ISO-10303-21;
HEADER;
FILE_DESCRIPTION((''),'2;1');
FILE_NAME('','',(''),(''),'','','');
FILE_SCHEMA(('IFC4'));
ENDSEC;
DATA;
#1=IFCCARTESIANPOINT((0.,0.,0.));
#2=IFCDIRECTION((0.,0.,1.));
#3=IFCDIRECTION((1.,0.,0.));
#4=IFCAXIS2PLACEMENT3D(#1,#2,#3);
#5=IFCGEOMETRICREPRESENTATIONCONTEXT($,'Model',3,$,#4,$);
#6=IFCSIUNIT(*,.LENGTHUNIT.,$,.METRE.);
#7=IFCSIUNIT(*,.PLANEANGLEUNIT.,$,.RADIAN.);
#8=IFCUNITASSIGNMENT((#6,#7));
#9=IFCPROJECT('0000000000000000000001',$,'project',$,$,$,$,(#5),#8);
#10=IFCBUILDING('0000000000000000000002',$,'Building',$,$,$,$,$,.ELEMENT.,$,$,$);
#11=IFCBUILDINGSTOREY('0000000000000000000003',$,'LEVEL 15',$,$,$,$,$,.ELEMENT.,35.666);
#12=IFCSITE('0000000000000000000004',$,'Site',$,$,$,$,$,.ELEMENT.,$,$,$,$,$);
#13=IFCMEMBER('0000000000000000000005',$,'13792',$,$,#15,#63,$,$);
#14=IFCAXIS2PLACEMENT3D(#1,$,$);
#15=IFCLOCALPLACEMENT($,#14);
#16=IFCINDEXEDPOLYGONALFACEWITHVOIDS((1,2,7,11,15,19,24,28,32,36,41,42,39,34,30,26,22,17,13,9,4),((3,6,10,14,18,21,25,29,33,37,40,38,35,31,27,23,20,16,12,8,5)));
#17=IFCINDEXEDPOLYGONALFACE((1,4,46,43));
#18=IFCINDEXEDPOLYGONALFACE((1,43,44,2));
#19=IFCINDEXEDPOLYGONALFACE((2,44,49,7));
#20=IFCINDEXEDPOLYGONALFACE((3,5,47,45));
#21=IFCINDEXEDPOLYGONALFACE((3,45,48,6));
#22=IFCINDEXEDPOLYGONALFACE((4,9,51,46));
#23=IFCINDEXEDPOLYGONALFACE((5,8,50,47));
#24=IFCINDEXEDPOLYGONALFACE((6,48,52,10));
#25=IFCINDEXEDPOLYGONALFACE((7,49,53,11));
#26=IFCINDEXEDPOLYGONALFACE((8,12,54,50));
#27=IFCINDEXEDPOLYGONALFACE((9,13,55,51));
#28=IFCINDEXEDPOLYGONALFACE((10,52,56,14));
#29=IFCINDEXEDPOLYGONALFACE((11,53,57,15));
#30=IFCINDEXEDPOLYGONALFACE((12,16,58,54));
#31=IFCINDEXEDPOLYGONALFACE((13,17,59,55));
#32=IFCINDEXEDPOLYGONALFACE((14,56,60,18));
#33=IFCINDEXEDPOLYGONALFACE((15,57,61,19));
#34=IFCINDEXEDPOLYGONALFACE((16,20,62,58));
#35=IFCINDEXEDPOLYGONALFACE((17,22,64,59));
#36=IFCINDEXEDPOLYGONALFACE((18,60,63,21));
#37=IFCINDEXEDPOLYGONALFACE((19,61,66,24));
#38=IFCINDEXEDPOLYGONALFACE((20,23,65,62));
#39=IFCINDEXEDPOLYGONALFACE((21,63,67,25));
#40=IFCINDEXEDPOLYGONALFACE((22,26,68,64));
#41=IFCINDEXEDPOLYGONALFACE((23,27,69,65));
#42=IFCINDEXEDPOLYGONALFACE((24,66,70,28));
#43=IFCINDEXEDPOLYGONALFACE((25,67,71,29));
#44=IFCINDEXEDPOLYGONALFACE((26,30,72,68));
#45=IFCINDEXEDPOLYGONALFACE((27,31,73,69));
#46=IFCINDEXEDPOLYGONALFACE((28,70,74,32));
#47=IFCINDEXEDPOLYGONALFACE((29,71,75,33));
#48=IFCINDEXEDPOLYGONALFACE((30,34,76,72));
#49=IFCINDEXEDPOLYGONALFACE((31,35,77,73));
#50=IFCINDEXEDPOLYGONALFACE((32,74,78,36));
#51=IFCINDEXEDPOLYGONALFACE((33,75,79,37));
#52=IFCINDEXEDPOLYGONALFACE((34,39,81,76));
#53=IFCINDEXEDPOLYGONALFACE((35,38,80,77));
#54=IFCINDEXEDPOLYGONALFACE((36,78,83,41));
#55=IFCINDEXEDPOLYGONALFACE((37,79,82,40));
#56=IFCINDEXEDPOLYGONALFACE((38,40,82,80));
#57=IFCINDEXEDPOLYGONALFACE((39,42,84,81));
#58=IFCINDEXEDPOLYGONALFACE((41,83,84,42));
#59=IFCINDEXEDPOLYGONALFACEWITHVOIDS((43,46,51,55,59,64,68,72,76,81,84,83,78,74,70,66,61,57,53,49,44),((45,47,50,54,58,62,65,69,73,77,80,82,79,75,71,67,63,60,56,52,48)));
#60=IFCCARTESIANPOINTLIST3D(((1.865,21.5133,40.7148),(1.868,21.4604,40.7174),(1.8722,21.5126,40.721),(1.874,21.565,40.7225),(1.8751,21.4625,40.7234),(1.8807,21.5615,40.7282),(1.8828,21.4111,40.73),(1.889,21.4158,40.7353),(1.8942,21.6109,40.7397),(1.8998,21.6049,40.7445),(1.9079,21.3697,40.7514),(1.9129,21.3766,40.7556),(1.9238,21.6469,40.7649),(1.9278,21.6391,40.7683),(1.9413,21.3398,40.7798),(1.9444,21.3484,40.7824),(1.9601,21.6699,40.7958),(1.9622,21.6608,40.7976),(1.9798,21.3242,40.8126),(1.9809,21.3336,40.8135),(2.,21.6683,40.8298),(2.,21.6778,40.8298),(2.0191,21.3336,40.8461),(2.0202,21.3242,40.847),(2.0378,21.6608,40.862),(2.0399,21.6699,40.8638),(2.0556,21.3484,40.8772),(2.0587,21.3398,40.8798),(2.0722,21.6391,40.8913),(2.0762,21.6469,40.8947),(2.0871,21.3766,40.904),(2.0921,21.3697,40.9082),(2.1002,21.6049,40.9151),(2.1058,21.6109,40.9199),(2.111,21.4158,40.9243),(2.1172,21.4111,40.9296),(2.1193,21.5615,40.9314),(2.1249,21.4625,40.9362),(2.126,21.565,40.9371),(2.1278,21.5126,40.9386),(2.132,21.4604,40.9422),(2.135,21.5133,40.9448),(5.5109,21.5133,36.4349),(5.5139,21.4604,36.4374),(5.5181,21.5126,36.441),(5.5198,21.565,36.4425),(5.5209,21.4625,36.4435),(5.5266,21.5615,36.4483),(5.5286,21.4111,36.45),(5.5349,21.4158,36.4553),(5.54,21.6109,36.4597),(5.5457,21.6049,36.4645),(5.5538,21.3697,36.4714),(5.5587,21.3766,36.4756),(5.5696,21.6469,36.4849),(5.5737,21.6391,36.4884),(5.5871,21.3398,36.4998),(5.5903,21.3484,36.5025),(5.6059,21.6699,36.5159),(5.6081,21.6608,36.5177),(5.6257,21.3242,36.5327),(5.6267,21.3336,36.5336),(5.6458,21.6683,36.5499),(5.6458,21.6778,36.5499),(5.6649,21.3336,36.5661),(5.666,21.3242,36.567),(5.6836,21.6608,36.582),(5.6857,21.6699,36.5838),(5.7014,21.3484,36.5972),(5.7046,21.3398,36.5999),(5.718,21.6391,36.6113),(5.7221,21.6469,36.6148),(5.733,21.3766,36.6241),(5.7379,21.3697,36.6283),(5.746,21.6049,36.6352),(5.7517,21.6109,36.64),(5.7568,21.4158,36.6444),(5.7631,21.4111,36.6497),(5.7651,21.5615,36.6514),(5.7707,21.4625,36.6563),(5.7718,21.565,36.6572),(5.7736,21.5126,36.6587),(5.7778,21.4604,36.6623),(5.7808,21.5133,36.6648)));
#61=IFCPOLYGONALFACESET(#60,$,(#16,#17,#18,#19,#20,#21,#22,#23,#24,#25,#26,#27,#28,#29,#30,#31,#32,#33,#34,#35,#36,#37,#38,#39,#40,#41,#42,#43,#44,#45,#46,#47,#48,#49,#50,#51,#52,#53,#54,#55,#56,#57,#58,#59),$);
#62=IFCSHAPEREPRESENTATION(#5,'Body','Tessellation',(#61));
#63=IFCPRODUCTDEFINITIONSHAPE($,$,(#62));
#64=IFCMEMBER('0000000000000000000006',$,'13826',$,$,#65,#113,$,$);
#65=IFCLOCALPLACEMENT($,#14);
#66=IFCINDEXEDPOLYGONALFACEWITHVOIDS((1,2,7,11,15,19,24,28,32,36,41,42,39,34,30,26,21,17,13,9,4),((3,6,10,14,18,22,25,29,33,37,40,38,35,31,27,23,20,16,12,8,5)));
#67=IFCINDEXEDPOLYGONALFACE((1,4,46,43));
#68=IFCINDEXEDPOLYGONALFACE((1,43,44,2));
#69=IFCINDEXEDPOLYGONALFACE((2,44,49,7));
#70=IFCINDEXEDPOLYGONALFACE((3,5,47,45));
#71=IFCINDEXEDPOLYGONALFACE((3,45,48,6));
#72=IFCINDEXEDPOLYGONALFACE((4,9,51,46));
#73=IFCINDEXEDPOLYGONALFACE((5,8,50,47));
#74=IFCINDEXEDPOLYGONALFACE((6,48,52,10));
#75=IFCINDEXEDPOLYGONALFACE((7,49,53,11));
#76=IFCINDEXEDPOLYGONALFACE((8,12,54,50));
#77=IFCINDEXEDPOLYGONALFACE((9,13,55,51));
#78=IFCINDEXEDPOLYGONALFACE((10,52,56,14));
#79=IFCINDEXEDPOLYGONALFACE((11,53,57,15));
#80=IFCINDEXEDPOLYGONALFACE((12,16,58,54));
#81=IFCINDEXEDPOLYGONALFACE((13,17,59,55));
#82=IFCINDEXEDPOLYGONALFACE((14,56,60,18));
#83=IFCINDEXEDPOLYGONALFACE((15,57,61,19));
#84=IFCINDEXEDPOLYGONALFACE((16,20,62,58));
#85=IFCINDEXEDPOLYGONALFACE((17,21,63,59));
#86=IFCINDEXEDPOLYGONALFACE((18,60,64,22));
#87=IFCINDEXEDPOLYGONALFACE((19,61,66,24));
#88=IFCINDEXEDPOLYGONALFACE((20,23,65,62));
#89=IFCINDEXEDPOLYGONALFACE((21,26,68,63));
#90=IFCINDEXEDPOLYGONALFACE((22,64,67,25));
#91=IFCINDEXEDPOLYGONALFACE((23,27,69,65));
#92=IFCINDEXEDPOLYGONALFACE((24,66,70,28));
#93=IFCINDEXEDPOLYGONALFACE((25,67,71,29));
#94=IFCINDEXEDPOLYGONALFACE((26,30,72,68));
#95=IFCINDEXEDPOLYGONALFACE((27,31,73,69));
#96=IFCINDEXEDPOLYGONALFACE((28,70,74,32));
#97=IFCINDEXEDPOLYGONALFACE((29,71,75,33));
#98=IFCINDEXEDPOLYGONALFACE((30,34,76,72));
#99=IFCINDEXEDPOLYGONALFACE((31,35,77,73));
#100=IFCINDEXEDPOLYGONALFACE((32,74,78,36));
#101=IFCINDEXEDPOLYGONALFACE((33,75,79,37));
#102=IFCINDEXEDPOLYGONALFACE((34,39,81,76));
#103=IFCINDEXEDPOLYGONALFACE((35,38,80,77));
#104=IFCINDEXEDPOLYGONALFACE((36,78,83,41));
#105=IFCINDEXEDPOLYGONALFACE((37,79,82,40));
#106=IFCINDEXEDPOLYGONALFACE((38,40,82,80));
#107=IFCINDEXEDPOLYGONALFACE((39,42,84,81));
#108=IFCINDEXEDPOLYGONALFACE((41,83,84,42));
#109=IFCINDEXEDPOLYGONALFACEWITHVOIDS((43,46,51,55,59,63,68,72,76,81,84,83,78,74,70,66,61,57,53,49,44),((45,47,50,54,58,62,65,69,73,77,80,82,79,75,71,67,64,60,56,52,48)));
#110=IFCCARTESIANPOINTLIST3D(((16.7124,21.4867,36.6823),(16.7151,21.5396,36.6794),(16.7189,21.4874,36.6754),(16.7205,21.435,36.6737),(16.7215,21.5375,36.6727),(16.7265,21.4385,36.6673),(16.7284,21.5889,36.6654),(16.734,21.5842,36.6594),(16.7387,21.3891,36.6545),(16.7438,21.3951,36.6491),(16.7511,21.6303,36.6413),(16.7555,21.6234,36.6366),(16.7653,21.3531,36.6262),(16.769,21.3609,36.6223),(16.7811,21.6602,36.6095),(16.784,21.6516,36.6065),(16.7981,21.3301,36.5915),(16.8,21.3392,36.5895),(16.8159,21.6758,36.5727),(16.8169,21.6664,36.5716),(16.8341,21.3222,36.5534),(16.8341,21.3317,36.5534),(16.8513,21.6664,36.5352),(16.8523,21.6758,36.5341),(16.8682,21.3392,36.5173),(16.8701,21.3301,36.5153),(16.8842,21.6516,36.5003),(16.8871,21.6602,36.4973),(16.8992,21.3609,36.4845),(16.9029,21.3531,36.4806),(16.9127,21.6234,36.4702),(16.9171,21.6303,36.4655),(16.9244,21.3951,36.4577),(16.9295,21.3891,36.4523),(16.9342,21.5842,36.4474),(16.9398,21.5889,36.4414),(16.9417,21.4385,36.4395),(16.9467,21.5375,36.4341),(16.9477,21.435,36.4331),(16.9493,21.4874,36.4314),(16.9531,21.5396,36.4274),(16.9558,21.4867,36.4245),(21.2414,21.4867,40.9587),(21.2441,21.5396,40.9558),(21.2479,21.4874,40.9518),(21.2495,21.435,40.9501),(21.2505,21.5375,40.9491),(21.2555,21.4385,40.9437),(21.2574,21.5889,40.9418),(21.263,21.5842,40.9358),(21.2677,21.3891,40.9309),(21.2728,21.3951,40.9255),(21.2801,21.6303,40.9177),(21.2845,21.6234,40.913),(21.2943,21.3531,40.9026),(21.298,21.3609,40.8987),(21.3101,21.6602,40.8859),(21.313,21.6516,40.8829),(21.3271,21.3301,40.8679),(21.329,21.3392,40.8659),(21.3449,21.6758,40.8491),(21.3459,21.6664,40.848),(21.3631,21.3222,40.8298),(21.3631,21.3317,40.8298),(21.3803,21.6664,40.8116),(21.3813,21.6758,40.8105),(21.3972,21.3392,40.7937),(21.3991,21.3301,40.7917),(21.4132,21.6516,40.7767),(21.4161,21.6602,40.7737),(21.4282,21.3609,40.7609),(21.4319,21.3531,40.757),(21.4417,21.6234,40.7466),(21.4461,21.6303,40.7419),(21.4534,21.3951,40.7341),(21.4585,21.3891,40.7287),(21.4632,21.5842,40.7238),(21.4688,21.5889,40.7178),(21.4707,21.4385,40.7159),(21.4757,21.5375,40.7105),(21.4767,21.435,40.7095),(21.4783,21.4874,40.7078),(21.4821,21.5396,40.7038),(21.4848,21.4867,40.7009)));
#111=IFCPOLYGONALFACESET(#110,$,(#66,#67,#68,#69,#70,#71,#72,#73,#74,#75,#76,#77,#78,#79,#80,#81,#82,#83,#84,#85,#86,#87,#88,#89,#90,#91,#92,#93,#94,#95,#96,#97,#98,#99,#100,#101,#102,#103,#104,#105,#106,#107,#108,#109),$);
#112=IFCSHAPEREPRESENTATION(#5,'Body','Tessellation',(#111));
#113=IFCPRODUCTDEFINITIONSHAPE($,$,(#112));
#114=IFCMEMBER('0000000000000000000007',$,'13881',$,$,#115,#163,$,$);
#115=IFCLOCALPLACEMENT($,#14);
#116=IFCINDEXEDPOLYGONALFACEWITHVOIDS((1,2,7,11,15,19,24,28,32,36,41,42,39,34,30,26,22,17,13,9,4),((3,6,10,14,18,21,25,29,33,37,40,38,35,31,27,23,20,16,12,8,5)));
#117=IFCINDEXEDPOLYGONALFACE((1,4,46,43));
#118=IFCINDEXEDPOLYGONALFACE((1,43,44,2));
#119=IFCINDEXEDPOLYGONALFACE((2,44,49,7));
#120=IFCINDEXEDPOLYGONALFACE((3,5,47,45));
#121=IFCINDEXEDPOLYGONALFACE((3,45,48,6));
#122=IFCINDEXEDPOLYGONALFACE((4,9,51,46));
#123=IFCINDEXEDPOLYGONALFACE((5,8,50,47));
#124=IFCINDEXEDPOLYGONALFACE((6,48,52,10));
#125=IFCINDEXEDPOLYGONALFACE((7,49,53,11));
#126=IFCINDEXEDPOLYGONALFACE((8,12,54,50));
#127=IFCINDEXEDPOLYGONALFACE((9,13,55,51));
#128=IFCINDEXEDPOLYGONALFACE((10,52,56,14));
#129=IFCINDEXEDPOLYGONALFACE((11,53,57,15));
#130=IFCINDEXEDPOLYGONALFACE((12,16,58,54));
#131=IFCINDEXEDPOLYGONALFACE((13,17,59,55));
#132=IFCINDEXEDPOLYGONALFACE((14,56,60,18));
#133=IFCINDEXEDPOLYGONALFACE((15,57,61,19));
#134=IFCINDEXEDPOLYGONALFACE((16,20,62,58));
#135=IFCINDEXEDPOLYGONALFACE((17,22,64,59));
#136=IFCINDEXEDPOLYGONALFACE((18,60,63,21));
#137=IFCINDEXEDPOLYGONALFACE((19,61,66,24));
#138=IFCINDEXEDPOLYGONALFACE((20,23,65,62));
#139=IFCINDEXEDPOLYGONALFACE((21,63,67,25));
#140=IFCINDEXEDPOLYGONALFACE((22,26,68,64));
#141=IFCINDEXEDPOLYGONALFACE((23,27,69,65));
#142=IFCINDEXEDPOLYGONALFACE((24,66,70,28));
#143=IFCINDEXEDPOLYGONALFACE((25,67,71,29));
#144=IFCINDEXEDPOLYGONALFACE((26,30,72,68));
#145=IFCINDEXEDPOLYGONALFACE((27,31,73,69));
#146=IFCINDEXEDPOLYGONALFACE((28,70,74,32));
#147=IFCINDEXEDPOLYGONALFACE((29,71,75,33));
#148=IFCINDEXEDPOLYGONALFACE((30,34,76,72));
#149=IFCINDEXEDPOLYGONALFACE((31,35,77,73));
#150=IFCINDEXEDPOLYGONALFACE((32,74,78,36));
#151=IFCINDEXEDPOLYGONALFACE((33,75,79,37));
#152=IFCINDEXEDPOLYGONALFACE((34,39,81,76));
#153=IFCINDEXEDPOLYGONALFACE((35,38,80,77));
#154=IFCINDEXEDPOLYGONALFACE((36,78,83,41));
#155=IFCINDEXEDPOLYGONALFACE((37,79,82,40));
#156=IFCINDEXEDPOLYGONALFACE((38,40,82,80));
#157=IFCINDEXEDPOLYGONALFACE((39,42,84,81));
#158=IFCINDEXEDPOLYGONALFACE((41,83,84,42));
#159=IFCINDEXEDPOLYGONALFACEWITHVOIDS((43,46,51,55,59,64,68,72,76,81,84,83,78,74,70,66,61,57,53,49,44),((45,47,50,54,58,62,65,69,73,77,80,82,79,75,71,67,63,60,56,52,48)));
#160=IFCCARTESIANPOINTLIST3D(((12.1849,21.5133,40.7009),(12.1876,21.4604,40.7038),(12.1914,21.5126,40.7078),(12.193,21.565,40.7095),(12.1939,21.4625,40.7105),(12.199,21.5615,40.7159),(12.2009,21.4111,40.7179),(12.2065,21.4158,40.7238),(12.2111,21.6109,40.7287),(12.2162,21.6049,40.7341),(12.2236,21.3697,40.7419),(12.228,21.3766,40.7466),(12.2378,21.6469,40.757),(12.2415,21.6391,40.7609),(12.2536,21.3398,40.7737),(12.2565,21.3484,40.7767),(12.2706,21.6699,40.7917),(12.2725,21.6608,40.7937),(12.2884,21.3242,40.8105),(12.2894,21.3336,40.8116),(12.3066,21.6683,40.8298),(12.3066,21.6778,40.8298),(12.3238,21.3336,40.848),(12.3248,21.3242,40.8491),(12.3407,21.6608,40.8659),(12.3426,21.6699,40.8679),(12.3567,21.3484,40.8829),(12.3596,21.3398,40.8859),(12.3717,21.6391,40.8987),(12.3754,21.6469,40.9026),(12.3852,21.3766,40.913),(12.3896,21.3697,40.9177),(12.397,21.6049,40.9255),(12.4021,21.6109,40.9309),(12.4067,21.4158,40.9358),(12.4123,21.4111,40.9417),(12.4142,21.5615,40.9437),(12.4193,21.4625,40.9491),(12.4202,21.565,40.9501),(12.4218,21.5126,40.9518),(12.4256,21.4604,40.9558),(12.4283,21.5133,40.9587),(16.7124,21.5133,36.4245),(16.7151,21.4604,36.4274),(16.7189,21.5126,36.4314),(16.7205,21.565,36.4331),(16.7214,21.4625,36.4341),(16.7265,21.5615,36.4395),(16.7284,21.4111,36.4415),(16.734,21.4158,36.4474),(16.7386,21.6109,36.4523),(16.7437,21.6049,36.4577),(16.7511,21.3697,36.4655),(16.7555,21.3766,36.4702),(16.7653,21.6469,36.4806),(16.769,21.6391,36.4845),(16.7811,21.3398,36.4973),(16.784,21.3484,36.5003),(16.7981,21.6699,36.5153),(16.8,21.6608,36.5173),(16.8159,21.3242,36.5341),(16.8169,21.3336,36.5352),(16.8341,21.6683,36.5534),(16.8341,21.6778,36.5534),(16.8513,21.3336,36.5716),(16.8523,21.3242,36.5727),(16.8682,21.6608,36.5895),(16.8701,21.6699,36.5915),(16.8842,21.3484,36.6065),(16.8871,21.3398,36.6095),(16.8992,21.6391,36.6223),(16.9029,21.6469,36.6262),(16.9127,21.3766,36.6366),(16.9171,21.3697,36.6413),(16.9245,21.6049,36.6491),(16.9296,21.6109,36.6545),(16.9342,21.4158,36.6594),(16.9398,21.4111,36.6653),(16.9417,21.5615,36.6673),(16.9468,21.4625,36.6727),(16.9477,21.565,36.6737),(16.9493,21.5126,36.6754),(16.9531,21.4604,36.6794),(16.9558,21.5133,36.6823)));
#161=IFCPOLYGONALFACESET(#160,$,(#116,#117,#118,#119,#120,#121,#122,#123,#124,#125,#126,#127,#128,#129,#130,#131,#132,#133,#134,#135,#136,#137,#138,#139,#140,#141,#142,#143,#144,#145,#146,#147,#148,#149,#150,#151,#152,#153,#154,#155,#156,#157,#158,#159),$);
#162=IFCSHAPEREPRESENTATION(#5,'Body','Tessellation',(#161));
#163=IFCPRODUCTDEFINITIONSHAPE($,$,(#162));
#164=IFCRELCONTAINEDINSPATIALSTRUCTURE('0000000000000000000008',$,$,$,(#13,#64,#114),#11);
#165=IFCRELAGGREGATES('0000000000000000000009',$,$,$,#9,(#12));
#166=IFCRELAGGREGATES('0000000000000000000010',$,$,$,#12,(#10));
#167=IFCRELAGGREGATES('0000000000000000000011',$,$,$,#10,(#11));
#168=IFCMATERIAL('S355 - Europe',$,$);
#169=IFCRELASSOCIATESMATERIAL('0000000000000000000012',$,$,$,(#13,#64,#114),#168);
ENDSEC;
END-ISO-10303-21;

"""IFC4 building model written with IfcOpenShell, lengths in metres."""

from ifc_helpers import new_model, si_unit, frame, origin_with_axes, origin_2d_with_axis, place, context, project, spatial, hollow_circle, extrude, material, material_profile, profile_set, profile_usage, element, save


model = new_model("IFC4")

# Units and contexts
model_context = context("Model", 3, world=origin_with_axes())
ifc_project = project(units=[si_unit("LENGTHUNIT", "METRE"), si_unit("PLANEANGLEUNIT", "RADIAN")], contexts=[model_context])

# Site, building, storey
site = spatial("IfcSite", under=ifc_project, Name="Site", CompositionType="ELEMENT")
building = spatial("IfcBuilding", under=site, Name="Building", CompositionType="ELEMENT")
storey = spatial("IfcBuildingStorey", under=building, Name="LEVEL 15", CompositionType="ELEMENT", Elevation=35.666)

# Shared definitions
ifc_material = material(Name="S355 - Europe")

# Members
ifc_material_profile_1 = material_profile(ifc_material, hollow_circle(Radius=0.1778, WallThickness=0.0095, at=origin_2d_with_axis()))
ifc_profile_set_1 = profile_set([ifc_material_profile_1])
ifc_profile_usage_1 = profile_usage(ifc_profile_set_1, cardinal=10)
member_1_placement = place(None, frame((2.0, 21.5, 40.8298), z_axis=(0.648463, 0.0, -0.761246), x_axis=(0.0, 1.0, 0.0)))
element("IfcMember", 1, at=member_1_placement, inside=storey, material=ifc_profile_usage_1, Name="13792", context=model_context, shape_type="SweptSolid", body=[
    extrude(hollow_circle(Radius=0.1778, WallThickness=0.0095, at=origin_2d_with_axis()), origin_with_axes(), (0.0, 0.0, 1.0), 5.6223),
])
ifc_material_profile_2 = material_profile(ifc_material, hollow_circle(Radius=0.1778, WallThickness=0.0095, at=origin_2d_with_axis()))
ifc_profile_set_2 = profile_set([ifc_material_profile_2])
ifc_profile_usage_2 = profile_usage(ifc_profile_set_2, cardinal=10)
member_2_placement = place(None, frame((21.3631, 21.5, 40.8298), z_axis=(-0.727092, 0.0, -0.68654), x_axis=(0.0, -1.0, 0.0)))
element("IfcMember", 2, at=member_2_placement, inside=storey, material=ifc_profile_usage_2, Name="13826", context=model_context, shape_type="SweptSolid", body=[
    extrude(hollow_circle(Radius=0.1778, WallThickness=0.0095, at=origin_2d_with_axis()), origin_with_axes(), (0.0, 0.0, 1.0), 6.2289),
])
ifc_material_profile_3 = material_profile(ifc_material, hollow_circle(Radius=0.1778, WallThickness=0.0095, at=origin_2d_with_axis()))
ifc_profile_set_3 = profile_set([ifc_material_profile_3])
ifc_profile_usage_3 = profile_usage(ifc_profile_set_3, cardinal=10)
member_3_placement = place(None, frame((12.3066, 21.5, 40.8298), z_axis=(0.726979, 0.0, -0.68666), x_axis=(0.0, 1.0, 0.0)))
element("IfcMember", 3, at=member_3_placement, inside=storey, material=ifc_profile_usage_3, Name="13881", context=model_context, shape_type="SweptSolid", body=[
    extrude(hollow_circle(Radius=0.1778, WallThickness=0.0095, at=origin_2d_with_axis()), origin_with_axes(), (0.0, 0.0, 1.0), 6.2278),
])

save(model, "model.ifc")
